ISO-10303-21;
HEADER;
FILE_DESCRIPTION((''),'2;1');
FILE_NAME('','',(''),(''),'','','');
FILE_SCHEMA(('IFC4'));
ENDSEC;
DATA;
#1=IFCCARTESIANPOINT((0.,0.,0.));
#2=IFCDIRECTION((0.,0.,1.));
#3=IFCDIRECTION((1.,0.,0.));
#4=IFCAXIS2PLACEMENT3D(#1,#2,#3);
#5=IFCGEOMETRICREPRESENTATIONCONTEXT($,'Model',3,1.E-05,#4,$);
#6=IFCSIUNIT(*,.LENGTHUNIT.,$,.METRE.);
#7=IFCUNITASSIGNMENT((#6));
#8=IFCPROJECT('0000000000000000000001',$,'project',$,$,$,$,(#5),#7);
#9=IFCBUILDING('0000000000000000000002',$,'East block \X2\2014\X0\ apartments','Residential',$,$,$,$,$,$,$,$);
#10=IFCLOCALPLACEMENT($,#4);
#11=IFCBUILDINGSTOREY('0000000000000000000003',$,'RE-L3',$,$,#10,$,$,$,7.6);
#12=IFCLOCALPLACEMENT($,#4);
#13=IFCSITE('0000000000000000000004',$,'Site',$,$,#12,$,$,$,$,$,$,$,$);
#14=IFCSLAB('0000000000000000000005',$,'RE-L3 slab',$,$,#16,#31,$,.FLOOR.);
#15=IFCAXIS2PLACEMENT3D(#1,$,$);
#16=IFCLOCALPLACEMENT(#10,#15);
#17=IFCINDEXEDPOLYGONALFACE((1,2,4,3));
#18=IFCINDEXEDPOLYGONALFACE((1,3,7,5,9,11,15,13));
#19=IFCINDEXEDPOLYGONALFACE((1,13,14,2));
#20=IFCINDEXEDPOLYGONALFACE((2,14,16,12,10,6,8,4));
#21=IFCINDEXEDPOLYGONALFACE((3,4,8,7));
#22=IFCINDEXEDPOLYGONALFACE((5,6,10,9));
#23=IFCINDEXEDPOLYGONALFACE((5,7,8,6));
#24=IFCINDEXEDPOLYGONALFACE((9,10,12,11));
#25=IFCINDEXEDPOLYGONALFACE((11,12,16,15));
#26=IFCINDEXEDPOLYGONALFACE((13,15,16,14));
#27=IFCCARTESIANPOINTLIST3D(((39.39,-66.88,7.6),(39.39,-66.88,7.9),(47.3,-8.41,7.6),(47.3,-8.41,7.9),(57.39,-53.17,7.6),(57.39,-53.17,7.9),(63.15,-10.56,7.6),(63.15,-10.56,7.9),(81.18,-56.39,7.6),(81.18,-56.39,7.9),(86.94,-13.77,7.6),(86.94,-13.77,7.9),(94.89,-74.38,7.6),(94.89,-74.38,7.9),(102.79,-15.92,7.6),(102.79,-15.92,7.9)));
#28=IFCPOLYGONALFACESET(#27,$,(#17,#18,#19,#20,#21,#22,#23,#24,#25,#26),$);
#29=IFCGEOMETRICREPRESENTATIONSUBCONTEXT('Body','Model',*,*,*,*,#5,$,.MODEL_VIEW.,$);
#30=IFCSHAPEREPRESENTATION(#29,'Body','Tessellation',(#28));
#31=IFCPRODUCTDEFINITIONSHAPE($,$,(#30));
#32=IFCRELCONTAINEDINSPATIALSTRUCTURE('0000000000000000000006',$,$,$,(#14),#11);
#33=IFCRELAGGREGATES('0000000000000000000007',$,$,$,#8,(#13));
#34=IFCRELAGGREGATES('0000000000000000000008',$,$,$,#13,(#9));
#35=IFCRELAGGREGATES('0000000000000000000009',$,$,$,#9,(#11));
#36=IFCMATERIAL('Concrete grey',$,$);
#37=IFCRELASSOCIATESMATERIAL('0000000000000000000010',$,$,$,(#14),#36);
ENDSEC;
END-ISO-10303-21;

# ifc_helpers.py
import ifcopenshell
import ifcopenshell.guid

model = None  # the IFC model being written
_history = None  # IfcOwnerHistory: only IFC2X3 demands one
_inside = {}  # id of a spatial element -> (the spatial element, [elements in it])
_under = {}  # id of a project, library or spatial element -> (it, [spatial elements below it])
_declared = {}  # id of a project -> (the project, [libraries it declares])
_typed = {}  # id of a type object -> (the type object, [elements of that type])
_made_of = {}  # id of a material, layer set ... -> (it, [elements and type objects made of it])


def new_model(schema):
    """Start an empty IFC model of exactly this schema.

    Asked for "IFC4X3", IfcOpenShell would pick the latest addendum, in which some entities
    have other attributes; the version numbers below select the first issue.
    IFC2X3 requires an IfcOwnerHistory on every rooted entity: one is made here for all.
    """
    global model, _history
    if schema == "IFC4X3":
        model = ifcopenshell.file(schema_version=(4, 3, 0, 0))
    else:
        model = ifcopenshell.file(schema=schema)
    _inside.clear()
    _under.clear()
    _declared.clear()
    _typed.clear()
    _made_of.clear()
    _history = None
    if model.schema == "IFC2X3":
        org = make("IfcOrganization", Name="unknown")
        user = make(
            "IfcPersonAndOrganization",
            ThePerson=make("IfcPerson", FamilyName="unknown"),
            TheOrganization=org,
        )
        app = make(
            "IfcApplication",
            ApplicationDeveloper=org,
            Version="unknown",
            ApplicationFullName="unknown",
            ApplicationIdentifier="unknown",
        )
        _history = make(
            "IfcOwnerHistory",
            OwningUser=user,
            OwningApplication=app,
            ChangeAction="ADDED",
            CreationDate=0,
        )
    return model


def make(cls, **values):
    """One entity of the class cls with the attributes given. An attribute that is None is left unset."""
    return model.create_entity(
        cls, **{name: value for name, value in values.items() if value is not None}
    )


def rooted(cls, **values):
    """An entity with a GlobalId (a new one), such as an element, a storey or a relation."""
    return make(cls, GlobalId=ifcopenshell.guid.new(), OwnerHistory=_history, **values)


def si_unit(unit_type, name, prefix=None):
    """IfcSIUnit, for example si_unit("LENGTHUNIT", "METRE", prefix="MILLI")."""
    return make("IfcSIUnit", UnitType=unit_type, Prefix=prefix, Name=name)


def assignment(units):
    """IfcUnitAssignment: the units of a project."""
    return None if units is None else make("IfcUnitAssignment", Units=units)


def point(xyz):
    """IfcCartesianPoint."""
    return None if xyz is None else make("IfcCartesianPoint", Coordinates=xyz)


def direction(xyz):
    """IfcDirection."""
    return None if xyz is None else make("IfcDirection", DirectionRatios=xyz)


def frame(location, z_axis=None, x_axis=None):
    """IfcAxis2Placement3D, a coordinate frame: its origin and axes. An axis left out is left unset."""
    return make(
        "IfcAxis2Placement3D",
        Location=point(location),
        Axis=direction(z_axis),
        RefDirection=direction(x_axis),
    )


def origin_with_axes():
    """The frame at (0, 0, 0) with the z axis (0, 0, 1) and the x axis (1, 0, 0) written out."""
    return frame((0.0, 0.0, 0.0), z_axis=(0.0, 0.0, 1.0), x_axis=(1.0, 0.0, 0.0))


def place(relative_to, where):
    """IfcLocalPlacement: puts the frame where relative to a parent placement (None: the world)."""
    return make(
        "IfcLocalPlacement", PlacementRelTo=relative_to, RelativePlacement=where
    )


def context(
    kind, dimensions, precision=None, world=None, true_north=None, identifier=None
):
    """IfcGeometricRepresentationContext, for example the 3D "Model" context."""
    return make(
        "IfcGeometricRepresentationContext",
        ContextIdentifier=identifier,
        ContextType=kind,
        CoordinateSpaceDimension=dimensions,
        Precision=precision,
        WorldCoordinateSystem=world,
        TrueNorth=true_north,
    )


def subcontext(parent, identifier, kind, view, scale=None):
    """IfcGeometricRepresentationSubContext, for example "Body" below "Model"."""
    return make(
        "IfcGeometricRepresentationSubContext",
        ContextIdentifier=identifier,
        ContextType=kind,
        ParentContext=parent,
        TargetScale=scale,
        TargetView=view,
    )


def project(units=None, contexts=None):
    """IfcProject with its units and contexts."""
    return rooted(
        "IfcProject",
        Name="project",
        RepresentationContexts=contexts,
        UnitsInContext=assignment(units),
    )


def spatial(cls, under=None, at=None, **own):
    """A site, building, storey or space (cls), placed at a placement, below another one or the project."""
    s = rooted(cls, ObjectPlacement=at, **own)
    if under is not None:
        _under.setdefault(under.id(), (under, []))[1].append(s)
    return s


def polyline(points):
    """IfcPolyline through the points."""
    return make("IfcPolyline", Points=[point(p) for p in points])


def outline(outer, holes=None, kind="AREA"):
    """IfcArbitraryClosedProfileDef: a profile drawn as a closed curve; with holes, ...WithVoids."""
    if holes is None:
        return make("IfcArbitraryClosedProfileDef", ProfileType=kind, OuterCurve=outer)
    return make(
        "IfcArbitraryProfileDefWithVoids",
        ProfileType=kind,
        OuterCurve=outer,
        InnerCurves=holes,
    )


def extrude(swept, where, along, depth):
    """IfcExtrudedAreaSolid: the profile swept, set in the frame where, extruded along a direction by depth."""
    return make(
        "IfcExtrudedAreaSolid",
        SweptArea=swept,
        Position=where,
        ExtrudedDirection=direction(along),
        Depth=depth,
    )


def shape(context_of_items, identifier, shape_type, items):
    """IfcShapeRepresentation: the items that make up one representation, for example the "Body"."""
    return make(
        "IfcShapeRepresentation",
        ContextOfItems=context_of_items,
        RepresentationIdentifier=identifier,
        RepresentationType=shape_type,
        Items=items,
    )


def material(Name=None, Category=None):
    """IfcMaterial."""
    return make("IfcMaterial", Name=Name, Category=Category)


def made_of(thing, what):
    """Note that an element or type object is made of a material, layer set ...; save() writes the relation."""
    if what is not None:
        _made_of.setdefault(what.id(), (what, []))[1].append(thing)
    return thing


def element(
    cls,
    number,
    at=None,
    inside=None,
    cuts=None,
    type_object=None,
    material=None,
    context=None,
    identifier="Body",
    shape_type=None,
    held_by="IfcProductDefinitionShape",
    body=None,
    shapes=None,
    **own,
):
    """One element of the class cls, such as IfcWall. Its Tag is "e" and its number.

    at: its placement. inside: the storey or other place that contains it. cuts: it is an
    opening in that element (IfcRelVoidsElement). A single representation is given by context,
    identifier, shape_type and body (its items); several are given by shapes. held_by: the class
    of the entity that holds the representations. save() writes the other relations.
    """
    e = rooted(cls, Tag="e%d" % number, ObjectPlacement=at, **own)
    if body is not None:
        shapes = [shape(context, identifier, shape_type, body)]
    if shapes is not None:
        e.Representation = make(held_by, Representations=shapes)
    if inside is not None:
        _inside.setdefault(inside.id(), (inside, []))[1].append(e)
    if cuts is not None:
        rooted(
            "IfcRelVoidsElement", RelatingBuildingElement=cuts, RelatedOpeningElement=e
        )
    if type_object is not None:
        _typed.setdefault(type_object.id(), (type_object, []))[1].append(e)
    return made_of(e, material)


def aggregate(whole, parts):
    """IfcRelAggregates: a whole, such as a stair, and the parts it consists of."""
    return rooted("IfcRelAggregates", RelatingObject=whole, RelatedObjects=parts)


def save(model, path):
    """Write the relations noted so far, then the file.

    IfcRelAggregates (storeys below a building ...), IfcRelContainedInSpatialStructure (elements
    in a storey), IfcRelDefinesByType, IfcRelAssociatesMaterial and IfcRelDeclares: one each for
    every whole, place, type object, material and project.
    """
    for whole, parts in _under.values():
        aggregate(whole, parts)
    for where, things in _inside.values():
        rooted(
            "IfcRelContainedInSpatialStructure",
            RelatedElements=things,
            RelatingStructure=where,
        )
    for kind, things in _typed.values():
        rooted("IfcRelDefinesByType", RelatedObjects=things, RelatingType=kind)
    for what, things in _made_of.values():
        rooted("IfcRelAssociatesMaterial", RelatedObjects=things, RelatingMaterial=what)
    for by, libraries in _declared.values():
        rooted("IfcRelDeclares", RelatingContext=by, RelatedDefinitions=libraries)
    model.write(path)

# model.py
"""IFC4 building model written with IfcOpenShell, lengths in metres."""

from ifc_helpers import new_model, si_unit, frame, origin_with_axes, place, context, subcontext, project, spatial, polyline, outline, extrude, material, element, save


model = new_model("IFC4")

# Units and contexts
model_context = context("Model", 3, precision=1e-05, world=origin_with_axes())
body_context = subcontext(model_context, "Body", "Model", "MODEL_VIEW")
ifc_project = project(units=[si_unit("LENGTHUNIT", "METRE")], contexts=[model_context])

# Site, building, storey
site_placement = place(None, origin_with_axes())
site = spatial("IfcSite", under=ifc_project, at=site_placement, Name="Site")
building = spatial("IfcBuilding", under=site, Name="East block — apartments", Description="Residential")
storey_placement = place(None, origin_with_axes())
storey = spatial("IfcBuildingStorey", under=building, at=storey_placement, Name="RE-L3", Elevation=7.6)

# Slab
ifc_material = material(Name="Concrete grey")
slab_placement = place(storey_placement, origin_with_axes())
element("IfcSlab", 1, at=slab_placement, inside=storey, material=ifc_material, Name="RE-L3 slab", PredefinedType="FLOOR", context=body_context, shape_type="SweptSolid", body=[
    extrude(outline(polyline([(39.39, -66.88), (94.89, -74.38), (102.79, -15.92), (86.94, -13.77), (81.18, -56.39), (57.39, -53.17), (63.15, -10.56), (47.3, -8.41), (39.39, -66.88)])), frame((0.0, 0.0, 7.6), z_axis=(0.0, 0.0, 1.0), x_axis=(1.0, 0.0, 0.0)), (0.0, 0.0, 1.0), 0.3),
])

save(model, "model.ifc")
